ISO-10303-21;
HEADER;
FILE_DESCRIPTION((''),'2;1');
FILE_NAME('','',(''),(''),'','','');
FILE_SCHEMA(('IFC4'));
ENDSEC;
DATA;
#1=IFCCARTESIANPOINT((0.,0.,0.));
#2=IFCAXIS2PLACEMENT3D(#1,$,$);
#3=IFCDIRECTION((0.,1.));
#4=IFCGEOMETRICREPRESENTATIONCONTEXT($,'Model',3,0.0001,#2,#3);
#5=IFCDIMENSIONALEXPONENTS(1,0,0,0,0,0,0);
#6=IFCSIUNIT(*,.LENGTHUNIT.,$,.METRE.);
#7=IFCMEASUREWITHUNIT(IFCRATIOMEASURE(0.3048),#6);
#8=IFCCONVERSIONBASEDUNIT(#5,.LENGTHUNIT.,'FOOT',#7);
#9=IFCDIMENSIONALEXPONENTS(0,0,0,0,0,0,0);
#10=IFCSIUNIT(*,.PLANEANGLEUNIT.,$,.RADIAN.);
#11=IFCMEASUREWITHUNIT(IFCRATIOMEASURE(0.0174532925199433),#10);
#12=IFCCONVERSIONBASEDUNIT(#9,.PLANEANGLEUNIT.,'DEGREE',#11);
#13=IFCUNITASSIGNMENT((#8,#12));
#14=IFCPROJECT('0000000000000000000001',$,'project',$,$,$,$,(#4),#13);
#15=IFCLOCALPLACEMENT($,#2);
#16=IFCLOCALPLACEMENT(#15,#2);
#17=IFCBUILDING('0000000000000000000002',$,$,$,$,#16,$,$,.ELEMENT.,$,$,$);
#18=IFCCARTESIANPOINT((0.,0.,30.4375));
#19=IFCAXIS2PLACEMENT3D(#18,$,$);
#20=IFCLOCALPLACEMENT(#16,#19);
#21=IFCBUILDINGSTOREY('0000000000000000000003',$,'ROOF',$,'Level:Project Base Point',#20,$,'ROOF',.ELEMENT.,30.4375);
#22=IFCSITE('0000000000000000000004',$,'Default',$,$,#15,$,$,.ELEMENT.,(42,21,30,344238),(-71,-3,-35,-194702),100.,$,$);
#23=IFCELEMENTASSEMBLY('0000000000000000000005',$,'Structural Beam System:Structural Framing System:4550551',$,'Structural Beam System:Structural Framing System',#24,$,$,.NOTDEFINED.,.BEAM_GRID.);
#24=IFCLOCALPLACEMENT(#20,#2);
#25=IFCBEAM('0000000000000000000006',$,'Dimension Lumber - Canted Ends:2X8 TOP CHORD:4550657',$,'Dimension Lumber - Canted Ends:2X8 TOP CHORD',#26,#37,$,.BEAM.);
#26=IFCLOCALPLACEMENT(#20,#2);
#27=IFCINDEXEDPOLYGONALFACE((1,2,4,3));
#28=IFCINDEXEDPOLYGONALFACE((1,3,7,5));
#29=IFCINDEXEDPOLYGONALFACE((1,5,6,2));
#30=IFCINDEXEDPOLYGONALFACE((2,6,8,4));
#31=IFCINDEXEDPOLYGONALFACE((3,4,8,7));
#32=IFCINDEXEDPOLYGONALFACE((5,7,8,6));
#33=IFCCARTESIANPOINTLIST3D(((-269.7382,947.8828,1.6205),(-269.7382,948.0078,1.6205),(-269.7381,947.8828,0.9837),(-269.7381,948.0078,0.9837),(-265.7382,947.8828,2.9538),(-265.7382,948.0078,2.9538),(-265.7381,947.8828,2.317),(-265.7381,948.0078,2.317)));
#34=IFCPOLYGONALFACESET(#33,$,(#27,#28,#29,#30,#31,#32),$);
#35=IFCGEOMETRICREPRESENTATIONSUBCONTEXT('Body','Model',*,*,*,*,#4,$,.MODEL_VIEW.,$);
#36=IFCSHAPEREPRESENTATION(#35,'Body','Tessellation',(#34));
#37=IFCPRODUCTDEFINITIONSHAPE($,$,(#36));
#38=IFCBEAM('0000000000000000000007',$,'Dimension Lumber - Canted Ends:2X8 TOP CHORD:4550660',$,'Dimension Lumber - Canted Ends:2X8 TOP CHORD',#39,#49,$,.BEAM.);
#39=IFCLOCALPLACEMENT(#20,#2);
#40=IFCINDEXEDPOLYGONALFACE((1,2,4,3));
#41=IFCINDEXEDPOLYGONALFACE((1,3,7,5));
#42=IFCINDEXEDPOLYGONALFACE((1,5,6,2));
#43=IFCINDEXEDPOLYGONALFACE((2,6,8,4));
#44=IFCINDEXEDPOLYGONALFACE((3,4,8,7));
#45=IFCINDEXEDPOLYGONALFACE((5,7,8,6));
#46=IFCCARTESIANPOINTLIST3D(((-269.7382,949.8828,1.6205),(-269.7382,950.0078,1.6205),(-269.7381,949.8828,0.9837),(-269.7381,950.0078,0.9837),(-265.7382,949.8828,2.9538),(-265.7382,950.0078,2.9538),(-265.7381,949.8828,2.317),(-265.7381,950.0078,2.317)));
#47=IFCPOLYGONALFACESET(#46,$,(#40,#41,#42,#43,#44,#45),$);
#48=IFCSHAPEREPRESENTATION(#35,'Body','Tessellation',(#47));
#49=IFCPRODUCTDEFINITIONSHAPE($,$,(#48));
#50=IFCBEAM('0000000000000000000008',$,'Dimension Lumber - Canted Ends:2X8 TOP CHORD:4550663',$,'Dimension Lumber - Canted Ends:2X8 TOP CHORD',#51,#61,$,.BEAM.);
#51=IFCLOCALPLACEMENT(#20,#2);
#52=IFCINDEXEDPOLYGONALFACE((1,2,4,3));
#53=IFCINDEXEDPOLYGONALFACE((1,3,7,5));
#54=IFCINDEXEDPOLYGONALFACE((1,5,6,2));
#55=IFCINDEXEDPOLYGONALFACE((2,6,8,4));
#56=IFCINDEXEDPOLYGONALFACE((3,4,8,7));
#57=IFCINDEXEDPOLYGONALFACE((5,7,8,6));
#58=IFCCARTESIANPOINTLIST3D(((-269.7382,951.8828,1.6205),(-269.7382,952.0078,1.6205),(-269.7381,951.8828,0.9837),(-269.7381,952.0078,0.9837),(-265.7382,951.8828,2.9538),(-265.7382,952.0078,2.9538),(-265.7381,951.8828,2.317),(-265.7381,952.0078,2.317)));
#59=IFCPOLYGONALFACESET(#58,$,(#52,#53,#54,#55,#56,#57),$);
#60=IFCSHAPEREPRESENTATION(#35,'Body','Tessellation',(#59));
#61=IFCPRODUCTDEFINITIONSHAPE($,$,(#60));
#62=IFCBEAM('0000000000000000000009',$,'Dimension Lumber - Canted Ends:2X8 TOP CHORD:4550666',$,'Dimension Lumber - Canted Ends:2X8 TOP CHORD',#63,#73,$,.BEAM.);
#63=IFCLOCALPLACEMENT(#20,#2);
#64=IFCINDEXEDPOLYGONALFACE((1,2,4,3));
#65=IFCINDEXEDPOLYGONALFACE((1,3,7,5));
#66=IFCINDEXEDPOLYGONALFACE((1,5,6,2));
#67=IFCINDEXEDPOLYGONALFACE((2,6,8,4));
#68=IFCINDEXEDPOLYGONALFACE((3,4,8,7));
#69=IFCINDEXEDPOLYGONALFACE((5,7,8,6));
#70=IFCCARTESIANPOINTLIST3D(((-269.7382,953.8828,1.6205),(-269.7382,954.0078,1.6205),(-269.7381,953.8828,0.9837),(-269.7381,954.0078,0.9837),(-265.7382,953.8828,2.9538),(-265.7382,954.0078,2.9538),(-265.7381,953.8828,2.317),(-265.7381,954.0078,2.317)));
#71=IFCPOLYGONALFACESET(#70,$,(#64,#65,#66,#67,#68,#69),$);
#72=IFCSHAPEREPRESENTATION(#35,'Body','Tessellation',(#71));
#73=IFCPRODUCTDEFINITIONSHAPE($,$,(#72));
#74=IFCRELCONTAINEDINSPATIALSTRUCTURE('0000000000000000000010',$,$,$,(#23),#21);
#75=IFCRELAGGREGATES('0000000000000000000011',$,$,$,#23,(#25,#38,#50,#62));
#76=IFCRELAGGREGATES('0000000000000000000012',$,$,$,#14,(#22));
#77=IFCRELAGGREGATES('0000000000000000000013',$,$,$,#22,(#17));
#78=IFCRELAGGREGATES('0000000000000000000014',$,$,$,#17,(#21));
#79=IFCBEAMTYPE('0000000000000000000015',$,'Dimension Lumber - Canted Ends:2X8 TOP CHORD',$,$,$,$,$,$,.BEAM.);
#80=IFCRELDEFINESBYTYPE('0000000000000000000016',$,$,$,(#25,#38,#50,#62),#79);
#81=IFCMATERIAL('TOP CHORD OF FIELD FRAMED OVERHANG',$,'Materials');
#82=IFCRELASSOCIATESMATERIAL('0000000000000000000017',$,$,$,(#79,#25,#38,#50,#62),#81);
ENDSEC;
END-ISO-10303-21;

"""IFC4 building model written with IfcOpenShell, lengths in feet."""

from ifc_helpers import new_model, entity, si_unit, converted_unit, direction, frame, frame_2d, origin, origin_2d_with_axis, place, context, subcontext, project, spatial, rectangle, extrude, clip, halfspace, source, transform, mapped, material, material_profile, profile_set, profile_usage, type_object, type_shapes, element, aggregate, save


model = new_model("IFC4")

# Units and contexts
model_context = context("Model", 3, precision=0.0001, world=origin(), true_north=direction((0.0, 1.0)))
body_context = subcontext(model_context, "Body", "Model", "MODEL_VIEW")
ifc_project = project(units=[converted_unit("LENGTHUNIT", "FOOT", entity("IfcRatioMeasure", 0.3048), si_unit("LENGTHUNIT", "METRE"), dimensions=[1, 0, 0, 0, 0, 0, 0]), converted_unit("PLANEANGLEUNIT", "DEGREE", entity("IfcRatioMeasure", 0.0174532925199433), si_unit("PLANEANGLEUNIT", "RADIAN"), dimensions=[0, 0, 0, 0, 0, 0, 0])], contexts=[model_context])

# Site, building, storey
site_placement = place(None, origin())
site = spatial("IfcSite", under=ifc_project, at=site_placement, Name="Default", CompositionType="ELEMENT", RefLatitude=(42, 21, 30, 344238), RefLongitude=(-71, -3, -35, -194702), RefElevation=100.0)
building_placement = place(site_placement, origin())
building = spatial("IfcBuilding", under=site, at=building_placement, CompositionType="ELEMENT")
storey_placement = place(building_placement, frame((0.0, 0.0, 30.4375)))
storey = spatial("IfcBuildingStorey", under=building, at=storey_placement, Name="ROOF", ObjectType="Level:Project Base Point", LongName="ROOF", CompositionType="ELEMENT", Elevation=30.4375)

# Element assembly, beams
assembly_1_placement = place(storey_placement, origin())
assembly_1 = element("IfcElementAssembly", 1, at=assembly_1_placement, inside=storey, Name="Structural Beam System:Structural Framing System:4550551", ObjectType="Structural Beam System:Structural Framing System", AssemblyPlace="NOTDEFINED", PredefinedType="BEAM_GRID")
ifc_material_1 = material(Name="TOP CHORD OF FIELD FRAMED OVERHANG", Category="Materials")
ifc_material_profile_1 = material_profile(ifc_material_1, rectangle(XDim=0.6042, YDim=0.125, at=origin_2d_with_axis()), Name="2X8 TOP CHORD")
ifc_profile_set_1 = profile_set([ifc_material_profile_1], Name="2X8 TOP CHORD")
beam_type_1 = type_object("IfcBeamType", Name="Dimension Lumber - Canted Ends:2X8 TOP CHORD", PredefinedType="BEAM", material=ifc_profile_set_1)
shared_shape_1 = source(origin(), body_context, "Body", "Clipping", [
    clip(clip(extrude(rectangle(XDim=0.6042, YDim=0.125, at=frame_2d((0.0, 0.0), x_axis=(1.0, 0.0))), frame((-2.1082, 0.0, 0.0), z_axis=(1.0, 0.0, 0.0), x_axis=(0.0, 0.0, -1.0)), (0.0, 0.0, 1.0), 4.4177), halfspace(frame((2.1082, -0.0625, -0.3021), z_axis=(0.948711, 0.0, -0.316146), x_axis=(0.0, 1.0, 0.0)), False)), halfspace(frame((-1.9069, -0.0625, 0.3021), z_axis=(-0.948711, 0.0, 0.316146), x_axis=(0.0, 1.0, 0.0)), False)),
])
type_shapes(beam_type_1, [shared_shape_1])
ifc_profile_usage_1 = profile_usage(ifc_profile_set_1, cardinal=8)
beam_1_placement = place(assembly_1_placement, frame((-267.8337, 947.9453, 1.9369), z_axis=(-0.316228, 0.0, 0.948683), x_axis=(0.948683, 0.0, 0.316228)))
beam_1 = element("IfcBeam", 2, at=beam_1_placement, type_object=beam_type_1, material=ifc_profile_usage_1, Name="Dimension Lumber - Canted Ends:2X8 TOP CHORD:4550657", ObjectType="Dimension Lumber - Canted Ends:2X8 TOP CHORD", PredefinedType="BEAM", context=body_context, shape_type="MappedRepresentation", body=[
    mapped(shared_shape_1, transform((0.0, 0.0, 0.0), scale=1.0)),
])
ifc_profile_usage_2 = profile_usage(ifc_profile_set_1, cardinal=8)
beam_2_placement = place(assembly_1_placement, frame((-267.8337, 949.9453, 1.9369), z_axis=(-0.316228, 0.0, 0.948683), x_axis=(0.948683, 0.0, 0.316228)))
beam_2 = element("IfcBeam", 3, at=beam_2_placement, type_object=beam_type_1, material=ifc_profile_usage_2, Name="Dimension Lumber - Canted Ends:2X8 TOP CHORD:4550660", ObjectType="Dimension Lumber - Canted Ends:2X8 TOP CHORD", PredefinedType="BEAM", context=body_context, shape_type="MappedRepresentation", body=[
    mapped(shared_shape_1, transform((0.0, 0.0, 0.0), scale=1.0)),
])
ifc_profile_usage_3 = profile_usage(ifc_profile_set_1, cardinal=8)
beam_3_placement = place(assembly_1_placement, frame((-267.8337, 951.9453, 1.9369), z_axis=(-0.316228, 0.0, 0.948683), x_axis=(0.948683, 0.0, 0.316228)))
beam_3 = element("IfcBeam", 4, at=beam_3_placement, type_object=beam_type_1, material=ifc_profile_usage_3, Name="Dimension Lumber - Canted Ends:2X8 TOP CHORD:4550663", ObjectType="Dimension Lumber - Canted Ends:2X8 TOP CHORD", PredefinedType="BEAM", context=body_context, shape_type="MappedRepresentation", body=[
    mapped(shared_shape_1, transform((0.0, 0.0, 0.0), scale=1.0)),
])
ifc_profile_usage_4 = profile_usage(ifc_profile_set_1, cardinal=8)
beam_4_placement = place(assembly_1_placement, frame((-267.8337, 953.9453, 1.9369), z_axis=(-0.316228, 0.0, 0.948683), x_axis=(0.948683, 0.0, 0.316228)))
beam_4 = element("IfcBeam", 5, at=beam_4_placement, type_object=beam_type_1, material=ifc_profile_usage_4, Name="Dimension Lumber - Canted Ends:2X8 TOP CHORD:4550666", ObjectType="Dimension Lumber - Canted Ends:2X8 TOP CHORD", PredefinedType="BEAM", context=body_context, shape_type="MappedRepresentation", body=[
    mapped(shared_shape_1, transform((0.0, 0.0, 0.0), scale=1.0)),
])
aggregate(assembly_1, [beam_1, beam_2, beam_3, beam_4])

save(model, "model.ifc")
